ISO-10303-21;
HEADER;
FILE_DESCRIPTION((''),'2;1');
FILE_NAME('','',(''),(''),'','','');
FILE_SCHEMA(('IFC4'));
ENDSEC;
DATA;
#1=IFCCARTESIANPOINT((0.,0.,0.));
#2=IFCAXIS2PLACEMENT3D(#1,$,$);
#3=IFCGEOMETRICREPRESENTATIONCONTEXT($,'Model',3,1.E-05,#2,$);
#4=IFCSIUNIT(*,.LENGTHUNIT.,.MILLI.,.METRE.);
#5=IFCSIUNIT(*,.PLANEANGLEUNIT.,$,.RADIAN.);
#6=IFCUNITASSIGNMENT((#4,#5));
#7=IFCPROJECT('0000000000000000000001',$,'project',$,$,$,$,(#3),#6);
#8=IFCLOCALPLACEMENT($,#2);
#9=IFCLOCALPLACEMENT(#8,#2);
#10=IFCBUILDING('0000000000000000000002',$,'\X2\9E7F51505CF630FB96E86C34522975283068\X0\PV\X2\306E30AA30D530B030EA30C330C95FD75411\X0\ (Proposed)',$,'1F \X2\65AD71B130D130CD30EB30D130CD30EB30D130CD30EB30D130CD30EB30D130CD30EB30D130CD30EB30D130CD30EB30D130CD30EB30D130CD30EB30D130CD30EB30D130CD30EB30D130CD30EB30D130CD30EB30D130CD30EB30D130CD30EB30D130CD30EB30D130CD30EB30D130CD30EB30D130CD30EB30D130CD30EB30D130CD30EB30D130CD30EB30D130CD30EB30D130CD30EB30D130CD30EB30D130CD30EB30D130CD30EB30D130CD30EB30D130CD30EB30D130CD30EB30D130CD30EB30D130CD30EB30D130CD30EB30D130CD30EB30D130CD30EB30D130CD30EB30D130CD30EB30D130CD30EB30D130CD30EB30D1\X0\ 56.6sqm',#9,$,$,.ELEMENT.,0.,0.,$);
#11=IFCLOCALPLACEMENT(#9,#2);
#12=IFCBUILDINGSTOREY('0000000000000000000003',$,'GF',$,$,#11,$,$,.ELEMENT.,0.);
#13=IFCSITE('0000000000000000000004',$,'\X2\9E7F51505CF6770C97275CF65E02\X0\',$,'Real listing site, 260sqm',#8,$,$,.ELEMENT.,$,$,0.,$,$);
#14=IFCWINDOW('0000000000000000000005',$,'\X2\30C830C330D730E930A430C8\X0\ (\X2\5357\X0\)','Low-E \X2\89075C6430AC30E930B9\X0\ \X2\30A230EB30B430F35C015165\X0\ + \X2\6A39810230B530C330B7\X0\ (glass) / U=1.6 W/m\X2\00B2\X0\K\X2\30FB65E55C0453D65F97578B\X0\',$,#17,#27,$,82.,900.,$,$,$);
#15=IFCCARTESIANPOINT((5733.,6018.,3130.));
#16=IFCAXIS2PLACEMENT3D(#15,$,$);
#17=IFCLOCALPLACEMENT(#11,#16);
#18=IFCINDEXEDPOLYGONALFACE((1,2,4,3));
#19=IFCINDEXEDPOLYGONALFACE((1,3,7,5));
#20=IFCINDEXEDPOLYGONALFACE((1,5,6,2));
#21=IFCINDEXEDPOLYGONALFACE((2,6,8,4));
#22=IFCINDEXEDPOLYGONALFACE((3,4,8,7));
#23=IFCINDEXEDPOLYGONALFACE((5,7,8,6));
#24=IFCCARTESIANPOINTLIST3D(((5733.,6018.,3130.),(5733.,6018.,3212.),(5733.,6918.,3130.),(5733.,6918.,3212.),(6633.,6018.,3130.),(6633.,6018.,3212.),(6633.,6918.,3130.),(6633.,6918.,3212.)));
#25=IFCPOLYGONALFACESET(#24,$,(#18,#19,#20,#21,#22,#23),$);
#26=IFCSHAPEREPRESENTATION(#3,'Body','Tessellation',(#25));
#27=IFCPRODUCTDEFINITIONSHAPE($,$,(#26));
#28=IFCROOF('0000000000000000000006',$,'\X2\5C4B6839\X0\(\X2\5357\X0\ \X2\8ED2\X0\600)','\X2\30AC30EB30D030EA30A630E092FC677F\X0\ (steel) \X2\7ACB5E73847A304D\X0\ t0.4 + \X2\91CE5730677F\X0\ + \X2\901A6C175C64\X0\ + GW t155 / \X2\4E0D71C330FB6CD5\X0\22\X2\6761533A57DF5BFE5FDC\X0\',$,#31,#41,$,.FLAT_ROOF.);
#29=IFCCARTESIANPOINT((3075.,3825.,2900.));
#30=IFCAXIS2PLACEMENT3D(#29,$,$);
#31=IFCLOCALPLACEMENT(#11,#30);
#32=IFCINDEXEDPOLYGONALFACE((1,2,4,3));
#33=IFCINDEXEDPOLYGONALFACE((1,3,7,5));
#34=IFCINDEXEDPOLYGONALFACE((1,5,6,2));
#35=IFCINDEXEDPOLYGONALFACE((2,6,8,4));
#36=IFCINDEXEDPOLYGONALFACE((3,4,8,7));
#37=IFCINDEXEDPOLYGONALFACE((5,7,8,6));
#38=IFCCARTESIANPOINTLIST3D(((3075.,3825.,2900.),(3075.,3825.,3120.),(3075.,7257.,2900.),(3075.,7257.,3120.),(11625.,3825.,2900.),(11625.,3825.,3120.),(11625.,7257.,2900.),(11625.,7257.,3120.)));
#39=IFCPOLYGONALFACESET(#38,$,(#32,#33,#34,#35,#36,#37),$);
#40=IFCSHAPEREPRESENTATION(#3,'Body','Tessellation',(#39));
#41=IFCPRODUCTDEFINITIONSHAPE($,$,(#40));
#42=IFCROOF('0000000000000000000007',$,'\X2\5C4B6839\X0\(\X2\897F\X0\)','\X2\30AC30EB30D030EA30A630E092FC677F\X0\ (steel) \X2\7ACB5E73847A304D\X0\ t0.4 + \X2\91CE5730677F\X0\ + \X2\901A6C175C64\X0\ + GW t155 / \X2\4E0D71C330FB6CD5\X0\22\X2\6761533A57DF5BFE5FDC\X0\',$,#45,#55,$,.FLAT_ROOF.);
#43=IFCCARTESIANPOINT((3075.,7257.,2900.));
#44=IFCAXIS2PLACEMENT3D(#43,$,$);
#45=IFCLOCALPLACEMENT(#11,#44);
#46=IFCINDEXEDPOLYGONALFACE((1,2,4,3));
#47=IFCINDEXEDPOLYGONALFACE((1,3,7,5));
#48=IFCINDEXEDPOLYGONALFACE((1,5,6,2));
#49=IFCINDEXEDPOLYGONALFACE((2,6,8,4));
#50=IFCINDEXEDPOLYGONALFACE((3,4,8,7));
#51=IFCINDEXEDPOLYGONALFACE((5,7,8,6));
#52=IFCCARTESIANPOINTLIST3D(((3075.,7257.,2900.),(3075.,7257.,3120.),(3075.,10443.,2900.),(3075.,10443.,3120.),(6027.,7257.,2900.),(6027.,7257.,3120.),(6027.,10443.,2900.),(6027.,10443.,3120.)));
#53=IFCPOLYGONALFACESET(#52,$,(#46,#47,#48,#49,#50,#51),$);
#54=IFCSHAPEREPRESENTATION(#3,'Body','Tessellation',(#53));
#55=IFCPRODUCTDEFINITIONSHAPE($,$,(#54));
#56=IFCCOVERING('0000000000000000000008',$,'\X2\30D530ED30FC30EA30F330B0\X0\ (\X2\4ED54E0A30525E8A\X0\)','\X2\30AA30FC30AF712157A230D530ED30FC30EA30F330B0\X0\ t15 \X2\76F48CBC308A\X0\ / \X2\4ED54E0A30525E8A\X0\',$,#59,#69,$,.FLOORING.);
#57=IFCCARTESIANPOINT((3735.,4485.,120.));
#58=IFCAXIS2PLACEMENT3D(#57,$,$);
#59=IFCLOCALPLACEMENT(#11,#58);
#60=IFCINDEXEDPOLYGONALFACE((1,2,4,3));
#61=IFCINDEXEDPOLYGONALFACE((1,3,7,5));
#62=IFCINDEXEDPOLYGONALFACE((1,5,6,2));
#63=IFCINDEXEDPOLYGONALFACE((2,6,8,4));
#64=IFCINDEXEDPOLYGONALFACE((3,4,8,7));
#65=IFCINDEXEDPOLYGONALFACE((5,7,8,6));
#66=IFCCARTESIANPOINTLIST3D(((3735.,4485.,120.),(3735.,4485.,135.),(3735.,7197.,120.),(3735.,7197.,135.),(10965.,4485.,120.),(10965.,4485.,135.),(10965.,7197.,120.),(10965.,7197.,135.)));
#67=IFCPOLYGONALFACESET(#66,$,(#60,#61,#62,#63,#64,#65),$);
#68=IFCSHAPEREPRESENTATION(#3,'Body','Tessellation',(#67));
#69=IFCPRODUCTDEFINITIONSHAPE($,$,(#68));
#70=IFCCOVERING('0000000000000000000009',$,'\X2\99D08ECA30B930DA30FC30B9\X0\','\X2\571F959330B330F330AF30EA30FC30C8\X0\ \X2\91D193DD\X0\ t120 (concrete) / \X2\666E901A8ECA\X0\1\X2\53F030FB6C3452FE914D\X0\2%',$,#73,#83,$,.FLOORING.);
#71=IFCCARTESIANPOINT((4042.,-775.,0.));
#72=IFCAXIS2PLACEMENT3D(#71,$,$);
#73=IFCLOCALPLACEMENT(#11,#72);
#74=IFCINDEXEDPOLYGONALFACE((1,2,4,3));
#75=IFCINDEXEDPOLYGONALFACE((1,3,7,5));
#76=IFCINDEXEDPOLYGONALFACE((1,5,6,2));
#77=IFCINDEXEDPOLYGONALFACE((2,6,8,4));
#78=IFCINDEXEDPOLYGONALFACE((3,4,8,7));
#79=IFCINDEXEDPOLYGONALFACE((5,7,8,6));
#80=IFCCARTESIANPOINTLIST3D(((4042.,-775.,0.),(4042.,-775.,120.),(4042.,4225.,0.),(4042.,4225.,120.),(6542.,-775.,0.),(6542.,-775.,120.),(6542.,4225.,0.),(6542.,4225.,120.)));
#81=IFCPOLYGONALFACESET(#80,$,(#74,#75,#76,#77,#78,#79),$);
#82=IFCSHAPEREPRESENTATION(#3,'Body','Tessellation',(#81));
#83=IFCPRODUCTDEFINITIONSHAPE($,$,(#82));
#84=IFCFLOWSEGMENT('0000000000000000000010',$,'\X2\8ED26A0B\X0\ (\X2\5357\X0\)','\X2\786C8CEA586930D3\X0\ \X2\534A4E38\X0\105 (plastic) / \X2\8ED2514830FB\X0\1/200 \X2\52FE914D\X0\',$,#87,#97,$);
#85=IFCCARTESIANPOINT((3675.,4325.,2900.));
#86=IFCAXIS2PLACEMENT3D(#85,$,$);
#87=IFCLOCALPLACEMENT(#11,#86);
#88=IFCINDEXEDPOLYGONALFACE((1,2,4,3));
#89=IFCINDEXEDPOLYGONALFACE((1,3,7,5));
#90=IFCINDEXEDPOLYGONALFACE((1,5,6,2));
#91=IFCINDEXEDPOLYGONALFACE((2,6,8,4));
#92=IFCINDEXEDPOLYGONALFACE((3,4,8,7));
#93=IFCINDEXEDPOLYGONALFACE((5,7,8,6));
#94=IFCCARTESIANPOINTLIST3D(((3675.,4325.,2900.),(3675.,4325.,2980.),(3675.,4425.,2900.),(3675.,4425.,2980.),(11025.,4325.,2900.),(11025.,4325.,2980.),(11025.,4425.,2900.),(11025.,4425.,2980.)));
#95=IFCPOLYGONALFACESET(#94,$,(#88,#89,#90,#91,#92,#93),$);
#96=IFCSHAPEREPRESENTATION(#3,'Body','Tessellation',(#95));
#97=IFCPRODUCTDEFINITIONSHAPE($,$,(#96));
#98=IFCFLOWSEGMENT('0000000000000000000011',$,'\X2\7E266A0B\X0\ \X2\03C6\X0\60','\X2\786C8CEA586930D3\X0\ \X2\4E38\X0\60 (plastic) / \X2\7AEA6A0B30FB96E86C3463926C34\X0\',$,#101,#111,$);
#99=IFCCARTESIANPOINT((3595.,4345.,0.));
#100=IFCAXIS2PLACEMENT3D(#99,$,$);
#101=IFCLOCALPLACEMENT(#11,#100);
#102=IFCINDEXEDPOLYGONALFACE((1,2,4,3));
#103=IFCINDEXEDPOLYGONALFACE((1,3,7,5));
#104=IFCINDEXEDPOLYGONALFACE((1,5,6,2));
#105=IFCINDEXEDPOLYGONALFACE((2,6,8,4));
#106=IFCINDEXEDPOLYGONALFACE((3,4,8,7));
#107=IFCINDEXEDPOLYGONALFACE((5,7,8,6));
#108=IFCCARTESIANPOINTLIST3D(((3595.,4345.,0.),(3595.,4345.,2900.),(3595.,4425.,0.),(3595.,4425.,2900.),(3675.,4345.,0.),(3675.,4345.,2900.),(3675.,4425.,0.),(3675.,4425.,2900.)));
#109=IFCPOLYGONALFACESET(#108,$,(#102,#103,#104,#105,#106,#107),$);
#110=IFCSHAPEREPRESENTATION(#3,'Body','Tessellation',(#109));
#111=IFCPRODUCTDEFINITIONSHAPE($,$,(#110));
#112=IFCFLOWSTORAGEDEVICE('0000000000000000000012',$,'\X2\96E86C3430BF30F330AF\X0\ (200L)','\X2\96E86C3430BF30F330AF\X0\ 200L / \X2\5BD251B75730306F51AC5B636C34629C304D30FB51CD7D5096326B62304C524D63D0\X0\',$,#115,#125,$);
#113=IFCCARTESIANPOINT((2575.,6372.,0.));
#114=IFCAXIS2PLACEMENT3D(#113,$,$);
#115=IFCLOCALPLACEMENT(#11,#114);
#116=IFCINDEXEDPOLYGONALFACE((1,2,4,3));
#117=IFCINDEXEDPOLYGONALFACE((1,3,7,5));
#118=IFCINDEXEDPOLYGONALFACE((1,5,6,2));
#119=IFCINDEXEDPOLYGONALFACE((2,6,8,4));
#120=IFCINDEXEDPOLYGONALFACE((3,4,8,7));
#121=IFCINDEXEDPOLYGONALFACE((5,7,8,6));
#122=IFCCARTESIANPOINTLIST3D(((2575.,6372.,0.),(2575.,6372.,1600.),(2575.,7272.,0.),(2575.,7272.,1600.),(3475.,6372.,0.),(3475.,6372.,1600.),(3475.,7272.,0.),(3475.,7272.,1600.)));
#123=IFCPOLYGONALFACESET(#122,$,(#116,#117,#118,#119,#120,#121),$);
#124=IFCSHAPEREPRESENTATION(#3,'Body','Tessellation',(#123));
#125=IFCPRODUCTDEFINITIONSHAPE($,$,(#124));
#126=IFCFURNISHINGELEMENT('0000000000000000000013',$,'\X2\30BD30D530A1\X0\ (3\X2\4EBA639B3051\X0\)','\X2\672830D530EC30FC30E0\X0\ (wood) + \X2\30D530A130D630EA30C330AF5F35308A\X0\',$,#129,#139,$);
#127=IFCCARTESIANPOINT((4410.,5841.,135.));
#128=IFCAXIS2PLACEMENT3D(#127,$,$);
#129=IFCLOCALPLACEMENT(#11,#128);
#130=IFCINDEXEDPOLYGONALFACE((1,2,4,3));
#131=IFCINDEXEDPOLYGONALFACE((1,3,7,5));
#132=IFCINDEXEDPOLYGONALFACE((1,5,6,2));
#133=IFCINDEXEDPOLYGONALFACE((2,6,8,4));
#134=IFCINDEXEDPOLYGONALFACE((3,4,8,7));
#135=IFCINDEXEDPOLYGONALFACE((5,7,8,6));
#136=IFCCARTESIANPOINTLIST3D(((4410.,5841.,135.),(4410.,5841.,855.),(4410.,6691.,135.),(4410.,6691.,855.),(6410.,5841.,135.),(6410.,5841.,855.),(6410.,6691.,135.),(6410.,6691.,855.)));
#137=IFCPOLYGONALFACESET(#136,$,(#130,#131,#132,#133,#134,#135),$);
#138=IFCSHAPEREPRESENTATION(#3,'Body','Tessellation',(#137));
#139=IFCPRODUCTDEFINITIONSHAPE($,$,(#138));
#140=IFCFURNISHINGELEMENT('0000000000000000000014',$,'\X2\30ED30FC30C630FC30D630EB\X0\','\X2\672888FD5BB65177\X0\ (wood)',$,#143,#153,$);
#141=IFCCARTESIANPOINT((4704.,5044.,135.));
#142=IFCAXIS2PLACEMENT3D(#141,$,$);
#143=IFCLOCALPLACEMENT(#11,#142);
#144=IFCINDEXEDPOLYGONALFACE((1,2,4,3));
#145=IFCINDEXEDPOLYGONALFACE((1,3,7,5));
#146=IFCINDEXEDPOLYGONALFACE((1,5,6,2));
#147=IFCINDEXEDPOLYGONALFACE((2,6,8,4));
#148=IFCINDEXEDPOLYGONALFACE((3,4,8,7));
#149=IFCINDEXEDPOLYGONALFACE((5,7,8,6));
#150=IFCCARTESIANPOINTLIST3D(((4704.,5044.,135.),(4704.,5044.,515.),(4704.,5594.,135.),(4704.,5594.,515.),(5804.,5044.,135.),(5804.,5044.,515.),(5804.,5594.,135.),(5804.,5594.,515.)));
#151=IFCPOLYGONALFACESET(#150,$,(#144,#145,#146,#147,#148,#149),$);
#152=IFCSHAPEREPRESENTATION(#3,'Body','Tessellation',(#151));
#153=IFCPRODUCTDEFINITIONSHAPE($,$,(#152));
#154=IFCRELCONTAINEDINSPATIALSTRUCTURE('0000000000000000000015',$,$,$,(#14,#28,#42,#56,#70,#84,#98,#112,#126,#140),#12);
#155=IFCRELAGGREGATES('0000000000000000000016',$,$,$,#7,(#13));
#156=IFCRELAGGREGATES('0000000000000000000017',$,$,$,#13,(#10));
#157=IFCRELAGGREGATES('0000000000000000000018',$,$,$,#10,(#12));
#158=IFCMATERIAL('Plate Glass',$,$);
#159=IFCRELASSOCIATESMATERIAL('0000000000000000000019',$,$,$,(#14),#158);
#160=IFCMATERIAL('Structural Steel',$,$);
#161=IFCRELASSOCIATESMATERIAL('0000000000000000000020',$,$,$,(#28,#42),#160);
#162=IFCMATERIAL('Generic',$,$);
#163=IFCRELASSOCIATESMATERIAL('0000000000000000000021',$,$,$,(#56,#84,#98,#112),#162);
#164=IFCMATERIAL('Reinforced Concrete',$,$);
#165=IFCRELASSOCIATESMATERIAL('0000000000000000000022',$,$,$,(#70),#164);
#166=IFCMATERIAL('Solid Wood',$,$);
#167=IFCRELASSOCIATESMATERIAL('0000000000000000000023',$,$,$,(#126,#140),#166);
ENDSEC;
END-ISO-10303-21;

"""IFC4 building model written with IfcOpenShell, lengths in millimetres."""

from ifc_helpers import new_model, si_unit, frame, frame_2d, origin, place, context, project, spatial, rectangle, extrude, material, element, save


model = new_model("IFC4")

# Units and contexts
model_context = context("Model", 3, precision=1e-05, world=origin())
ifc_project = project(units=[si_unit("LENGTHUNIT", "METRE", prefix="MILLI"), si_unit("PLANEANGLEUNIT", "RADIAN")], contexts=[model_context])

# Site, building, storey
site_placement = place(None, origin())
site = spatial("IfcSite", under=ifc_project, at=site_placement, Name="鹿児島県霧島市", ObjectType="Real listing site, 260sqm", CompositionType="ELEMENT", RefElevation=0.0)
building_placement = place(site_placement, origin())
building = spatial("IfcBuilding", under=site, at=building_placement, Name="鹿児島・雨水利用とPVのオフグリッド志向 (Proposed)", ObjectType="1F 断熱パネルパネルパネルパネルパネルパネルパネルパネルパネルパネルパネルパネルパネルパネルパネルパネルパネルパネルパネルパネルパネルパネルパネルパネルパネルパネルパネルパネルパネルパネルパネルパネルパネルパネルパネルパネルパネルパネルパネルパ 56.6sqm", CompositionType="ELEMENT", ElevationOfRefHeight=0.0, ElevationOfTerrain=0.0)
storey_placement = place(building_placement, origin())
storey = spatial("IfcBuildingStorey", under=building, at=storey_placement, Name="GF", CompositionType="ELEMENT", Elevation=0.0)

# Shared definitions
ifc_material_1 = material(Name="Solid Wood")

# Shared definitions
ifc_material_2 = material(Name="Reinforced Concrete")

# Shared definitions
ifc_material_3 = material(Name="Plate Glass")

# Window
window_1_placement = place(storey_placement, frame((5733.0, 6018.0, 3130.0)))
element("IfcWindow", 1, at=window_1_placement, inside=storey, material=ifc_material_3, Name="トップライト (南)", Description="Low-E 複層ガラス アルゴン封入 + 樹脂サッシ (glass) / U=1.6 W/m²K・日射取得型", OverallHeight=82.0, OverallWidth=900.0, context=model_context, shape_type="SweptSolid", body=[
    extrude(rectangle(XDim=900.0, YDim=900.0, at=frame_2d((450.0, 450.0))), frame((5733.0, 6018.0, 3130.0)), (0.0, 0.0, 1.0), 82.0),
])

# Roofs
ifc_material_4 = material(Name="Structural Steel")
roof_1_placement = place(storey_placement, frame((3075.0, 3825.0, 2900.0)))
element("IfcRoof", 2, at=roof_1_placement, inside=storey, material=ifc_material_4, Name="屋根(南 軒600)", Description="ガルバリウム鋼板 (steel) 立平葺き t0.4 + 野地板 + 通気層 + GW t155 / 不燃・法22条区域対応", PredefinedType="FLAT_ROOF", context=model_context, shape_type="SweptSolid", body=[
    extrude(rectangle(XDim=8550.0, YDim=3432.0, at=frame_2d((4275.0, 1716.0))), frame((3075.0, 3825.0, 2900.0)), (0.0, 0.0, 1.0), 220.0),
])
roof_2_placement = place(storey_placement, frame((3075.0, 7257.0, 2900.0)))
element("IfcRoof", 3, at=roof_2_placement, inside=storey, material=ifc_material_4, Name="屋根(西)", Description="ガルバリウム鋼板 (steel) 立平葺き t0.4 + 野地板 + 通気層 + GW t155 / 不燃・法22条区域対応", PredefinedType="FLAT_ROOF", context=model_context, shape_type="SweptSolid", body=[
    extrude(rectangle(XDim=2952.0, YDim=3186.0, at=frame_2d((1476.0, 1593.0))), frame((3075.0, 7257.0, 2900.0)), (0.0, 0.0, 1.0), 220.0),
])

# Coverings
ifc_material_5 = material(Name="Generic")
covering_1_placement = place(storey_placement, frame((3735.0, 4485.0, 120.0)))
element("IfcCovering", 4, at=covering_1_placement, inside=storey, material=ifc_material_5, Name="フローリング (仕上げ床)", Description="オーク無垢フローリング t15 直貼り / 仕上げ床", PredefinedType="FLOORING", context=model_context, shape_type="SweptSolid", body=[
    extrude(rectangle(XDim=7230.0, YDim=2712.0, at=frame_2d((3615.0, 1356.0))), frame((3735.0, 4485.0, 120.0)), (0.0, 0.0, 1.0), 15.0),
])
covering_2_placement = place(storey_placement, frame((4042.0, -775.0, 0.0)))
element("IfcCovering", 5, at=covering_2_placement, inside=storey, material=ifc_material_2, Name="駐車スペース", Description="土間コンクリート 金鏝 t120 (concrete) / 普通車1台・水勾配2%", PredefinedType="FLOORING", context=model_context, shape_type="SweptSolid", body=[
    extrude(rectangle(XDim=2500.0, YDim=5000.0, at=frame_2d((1250.0, 2500.0))), frame((4042.0, -775.0, 0.0)), (0.0, 0.0, 1.0), 120.0),
])

# Flow segments
flow_segment_1_placement = place(storey_placement, frame((3675.0, 4325.0, 2900.0)))
element("IfcFlowSegment", 6, at=flow_segment_1_placement, inside=storey, material=ifc_material_5, Name="軒樋 (南)", Description="硬質塩ビ 半丸105 (plastic) / 軒先・1/200 勾配", context=model_context, shape_type="SweptSolid", body=[
    extrude(rectangle(XDim=7350.0, YDim=100.0, at=frame_2d((3675.0, 50.0))), frame((3675.0, 4325.0, 2900.0)), (0.0, 0.0, 1.0), 80.0),
])
flow_segment_2_placement = place(storey_placement, frame((3595.0, 4345.0, 0.0)))
element("IfcFlowSegment", 7, at=flow_segment_2_placement, inside=storey, material=ifc_material_5, Name="縦樋 φ60", Description="硬質塩ビ 丸60 (plastic) / 竪樋・雨水排水", context=model_context, shape_type="SweptSolid", body=[
    extrude(rectangle(XDim=80.0, YDim=80.0, at=frame_2d((40.0, 40.0))), frame((3595.0, 4345.0, 0.0)), (0.0, 0.0, 1.0), 2900.0),
])

# Flow storage device
flow_storage_device_placement = place(storey_placement, frame((2575.0, 6372.0, 0.0)))
element("IfcFlowStorageDevice", 8, at=flow_storage_device_placement, inside=storey, material=ifc_material_5, Name="雨水タンク (200L)", Description="雨水タンク 200L / 寒冷地は冬季水抜き・凍結防止が前提", context=model_context, shape_type="SweptSolid", body=[
    extrude(rectangle(XDim=900.0, YDim=900.0, at=frame_2d((450.0, 450.0))), frame((2575.0, 6372.0, 0.0)), (0.0, 0.0, 1.0), 1600.0),
])

# Furnishing elements
furnishing_1_placement = place(storey_placement, frame((4410.0, 5841.0, 135.0)))
element("IfcFurnishingElement", 9, at=furnishing_1_placement, inside=storey, material=ifc_material_1, Name="ソファ (3人掛け)", Description="木フレーム (wood) + ファブリック張り", context=model_context, shape_type="SweptSolid", body=[
    extrude(rectangle(XDim=2000.0, YDim=850.0, at=frame_2d((1000.0, 425.0))), frame((4410.0, 5841.0, 135.0)), (0.0, 0.0, 1.0), 720.0),
])
furnishing_2_placement = place(storey_placement, frame((4704.0, 5044.0, 135.0)))
element("IfcFurnishingElement", 10, at=furnishing_2_placement, inside=storey, material=ifc_material_1, Name="ローテーブル", Description="木製家具 (wood)", context=model_context, shape_type="SweptSolid", body=[
    extrude(rectangle(XDim=1100.0, YDim=550.0, at=frame_2d((550.0, 275.0))), frame((4704.0, 5044.0, 135.0)), (0.0, 0.0, 1.0), 380.0),
])

save(model, "model.ifc")
